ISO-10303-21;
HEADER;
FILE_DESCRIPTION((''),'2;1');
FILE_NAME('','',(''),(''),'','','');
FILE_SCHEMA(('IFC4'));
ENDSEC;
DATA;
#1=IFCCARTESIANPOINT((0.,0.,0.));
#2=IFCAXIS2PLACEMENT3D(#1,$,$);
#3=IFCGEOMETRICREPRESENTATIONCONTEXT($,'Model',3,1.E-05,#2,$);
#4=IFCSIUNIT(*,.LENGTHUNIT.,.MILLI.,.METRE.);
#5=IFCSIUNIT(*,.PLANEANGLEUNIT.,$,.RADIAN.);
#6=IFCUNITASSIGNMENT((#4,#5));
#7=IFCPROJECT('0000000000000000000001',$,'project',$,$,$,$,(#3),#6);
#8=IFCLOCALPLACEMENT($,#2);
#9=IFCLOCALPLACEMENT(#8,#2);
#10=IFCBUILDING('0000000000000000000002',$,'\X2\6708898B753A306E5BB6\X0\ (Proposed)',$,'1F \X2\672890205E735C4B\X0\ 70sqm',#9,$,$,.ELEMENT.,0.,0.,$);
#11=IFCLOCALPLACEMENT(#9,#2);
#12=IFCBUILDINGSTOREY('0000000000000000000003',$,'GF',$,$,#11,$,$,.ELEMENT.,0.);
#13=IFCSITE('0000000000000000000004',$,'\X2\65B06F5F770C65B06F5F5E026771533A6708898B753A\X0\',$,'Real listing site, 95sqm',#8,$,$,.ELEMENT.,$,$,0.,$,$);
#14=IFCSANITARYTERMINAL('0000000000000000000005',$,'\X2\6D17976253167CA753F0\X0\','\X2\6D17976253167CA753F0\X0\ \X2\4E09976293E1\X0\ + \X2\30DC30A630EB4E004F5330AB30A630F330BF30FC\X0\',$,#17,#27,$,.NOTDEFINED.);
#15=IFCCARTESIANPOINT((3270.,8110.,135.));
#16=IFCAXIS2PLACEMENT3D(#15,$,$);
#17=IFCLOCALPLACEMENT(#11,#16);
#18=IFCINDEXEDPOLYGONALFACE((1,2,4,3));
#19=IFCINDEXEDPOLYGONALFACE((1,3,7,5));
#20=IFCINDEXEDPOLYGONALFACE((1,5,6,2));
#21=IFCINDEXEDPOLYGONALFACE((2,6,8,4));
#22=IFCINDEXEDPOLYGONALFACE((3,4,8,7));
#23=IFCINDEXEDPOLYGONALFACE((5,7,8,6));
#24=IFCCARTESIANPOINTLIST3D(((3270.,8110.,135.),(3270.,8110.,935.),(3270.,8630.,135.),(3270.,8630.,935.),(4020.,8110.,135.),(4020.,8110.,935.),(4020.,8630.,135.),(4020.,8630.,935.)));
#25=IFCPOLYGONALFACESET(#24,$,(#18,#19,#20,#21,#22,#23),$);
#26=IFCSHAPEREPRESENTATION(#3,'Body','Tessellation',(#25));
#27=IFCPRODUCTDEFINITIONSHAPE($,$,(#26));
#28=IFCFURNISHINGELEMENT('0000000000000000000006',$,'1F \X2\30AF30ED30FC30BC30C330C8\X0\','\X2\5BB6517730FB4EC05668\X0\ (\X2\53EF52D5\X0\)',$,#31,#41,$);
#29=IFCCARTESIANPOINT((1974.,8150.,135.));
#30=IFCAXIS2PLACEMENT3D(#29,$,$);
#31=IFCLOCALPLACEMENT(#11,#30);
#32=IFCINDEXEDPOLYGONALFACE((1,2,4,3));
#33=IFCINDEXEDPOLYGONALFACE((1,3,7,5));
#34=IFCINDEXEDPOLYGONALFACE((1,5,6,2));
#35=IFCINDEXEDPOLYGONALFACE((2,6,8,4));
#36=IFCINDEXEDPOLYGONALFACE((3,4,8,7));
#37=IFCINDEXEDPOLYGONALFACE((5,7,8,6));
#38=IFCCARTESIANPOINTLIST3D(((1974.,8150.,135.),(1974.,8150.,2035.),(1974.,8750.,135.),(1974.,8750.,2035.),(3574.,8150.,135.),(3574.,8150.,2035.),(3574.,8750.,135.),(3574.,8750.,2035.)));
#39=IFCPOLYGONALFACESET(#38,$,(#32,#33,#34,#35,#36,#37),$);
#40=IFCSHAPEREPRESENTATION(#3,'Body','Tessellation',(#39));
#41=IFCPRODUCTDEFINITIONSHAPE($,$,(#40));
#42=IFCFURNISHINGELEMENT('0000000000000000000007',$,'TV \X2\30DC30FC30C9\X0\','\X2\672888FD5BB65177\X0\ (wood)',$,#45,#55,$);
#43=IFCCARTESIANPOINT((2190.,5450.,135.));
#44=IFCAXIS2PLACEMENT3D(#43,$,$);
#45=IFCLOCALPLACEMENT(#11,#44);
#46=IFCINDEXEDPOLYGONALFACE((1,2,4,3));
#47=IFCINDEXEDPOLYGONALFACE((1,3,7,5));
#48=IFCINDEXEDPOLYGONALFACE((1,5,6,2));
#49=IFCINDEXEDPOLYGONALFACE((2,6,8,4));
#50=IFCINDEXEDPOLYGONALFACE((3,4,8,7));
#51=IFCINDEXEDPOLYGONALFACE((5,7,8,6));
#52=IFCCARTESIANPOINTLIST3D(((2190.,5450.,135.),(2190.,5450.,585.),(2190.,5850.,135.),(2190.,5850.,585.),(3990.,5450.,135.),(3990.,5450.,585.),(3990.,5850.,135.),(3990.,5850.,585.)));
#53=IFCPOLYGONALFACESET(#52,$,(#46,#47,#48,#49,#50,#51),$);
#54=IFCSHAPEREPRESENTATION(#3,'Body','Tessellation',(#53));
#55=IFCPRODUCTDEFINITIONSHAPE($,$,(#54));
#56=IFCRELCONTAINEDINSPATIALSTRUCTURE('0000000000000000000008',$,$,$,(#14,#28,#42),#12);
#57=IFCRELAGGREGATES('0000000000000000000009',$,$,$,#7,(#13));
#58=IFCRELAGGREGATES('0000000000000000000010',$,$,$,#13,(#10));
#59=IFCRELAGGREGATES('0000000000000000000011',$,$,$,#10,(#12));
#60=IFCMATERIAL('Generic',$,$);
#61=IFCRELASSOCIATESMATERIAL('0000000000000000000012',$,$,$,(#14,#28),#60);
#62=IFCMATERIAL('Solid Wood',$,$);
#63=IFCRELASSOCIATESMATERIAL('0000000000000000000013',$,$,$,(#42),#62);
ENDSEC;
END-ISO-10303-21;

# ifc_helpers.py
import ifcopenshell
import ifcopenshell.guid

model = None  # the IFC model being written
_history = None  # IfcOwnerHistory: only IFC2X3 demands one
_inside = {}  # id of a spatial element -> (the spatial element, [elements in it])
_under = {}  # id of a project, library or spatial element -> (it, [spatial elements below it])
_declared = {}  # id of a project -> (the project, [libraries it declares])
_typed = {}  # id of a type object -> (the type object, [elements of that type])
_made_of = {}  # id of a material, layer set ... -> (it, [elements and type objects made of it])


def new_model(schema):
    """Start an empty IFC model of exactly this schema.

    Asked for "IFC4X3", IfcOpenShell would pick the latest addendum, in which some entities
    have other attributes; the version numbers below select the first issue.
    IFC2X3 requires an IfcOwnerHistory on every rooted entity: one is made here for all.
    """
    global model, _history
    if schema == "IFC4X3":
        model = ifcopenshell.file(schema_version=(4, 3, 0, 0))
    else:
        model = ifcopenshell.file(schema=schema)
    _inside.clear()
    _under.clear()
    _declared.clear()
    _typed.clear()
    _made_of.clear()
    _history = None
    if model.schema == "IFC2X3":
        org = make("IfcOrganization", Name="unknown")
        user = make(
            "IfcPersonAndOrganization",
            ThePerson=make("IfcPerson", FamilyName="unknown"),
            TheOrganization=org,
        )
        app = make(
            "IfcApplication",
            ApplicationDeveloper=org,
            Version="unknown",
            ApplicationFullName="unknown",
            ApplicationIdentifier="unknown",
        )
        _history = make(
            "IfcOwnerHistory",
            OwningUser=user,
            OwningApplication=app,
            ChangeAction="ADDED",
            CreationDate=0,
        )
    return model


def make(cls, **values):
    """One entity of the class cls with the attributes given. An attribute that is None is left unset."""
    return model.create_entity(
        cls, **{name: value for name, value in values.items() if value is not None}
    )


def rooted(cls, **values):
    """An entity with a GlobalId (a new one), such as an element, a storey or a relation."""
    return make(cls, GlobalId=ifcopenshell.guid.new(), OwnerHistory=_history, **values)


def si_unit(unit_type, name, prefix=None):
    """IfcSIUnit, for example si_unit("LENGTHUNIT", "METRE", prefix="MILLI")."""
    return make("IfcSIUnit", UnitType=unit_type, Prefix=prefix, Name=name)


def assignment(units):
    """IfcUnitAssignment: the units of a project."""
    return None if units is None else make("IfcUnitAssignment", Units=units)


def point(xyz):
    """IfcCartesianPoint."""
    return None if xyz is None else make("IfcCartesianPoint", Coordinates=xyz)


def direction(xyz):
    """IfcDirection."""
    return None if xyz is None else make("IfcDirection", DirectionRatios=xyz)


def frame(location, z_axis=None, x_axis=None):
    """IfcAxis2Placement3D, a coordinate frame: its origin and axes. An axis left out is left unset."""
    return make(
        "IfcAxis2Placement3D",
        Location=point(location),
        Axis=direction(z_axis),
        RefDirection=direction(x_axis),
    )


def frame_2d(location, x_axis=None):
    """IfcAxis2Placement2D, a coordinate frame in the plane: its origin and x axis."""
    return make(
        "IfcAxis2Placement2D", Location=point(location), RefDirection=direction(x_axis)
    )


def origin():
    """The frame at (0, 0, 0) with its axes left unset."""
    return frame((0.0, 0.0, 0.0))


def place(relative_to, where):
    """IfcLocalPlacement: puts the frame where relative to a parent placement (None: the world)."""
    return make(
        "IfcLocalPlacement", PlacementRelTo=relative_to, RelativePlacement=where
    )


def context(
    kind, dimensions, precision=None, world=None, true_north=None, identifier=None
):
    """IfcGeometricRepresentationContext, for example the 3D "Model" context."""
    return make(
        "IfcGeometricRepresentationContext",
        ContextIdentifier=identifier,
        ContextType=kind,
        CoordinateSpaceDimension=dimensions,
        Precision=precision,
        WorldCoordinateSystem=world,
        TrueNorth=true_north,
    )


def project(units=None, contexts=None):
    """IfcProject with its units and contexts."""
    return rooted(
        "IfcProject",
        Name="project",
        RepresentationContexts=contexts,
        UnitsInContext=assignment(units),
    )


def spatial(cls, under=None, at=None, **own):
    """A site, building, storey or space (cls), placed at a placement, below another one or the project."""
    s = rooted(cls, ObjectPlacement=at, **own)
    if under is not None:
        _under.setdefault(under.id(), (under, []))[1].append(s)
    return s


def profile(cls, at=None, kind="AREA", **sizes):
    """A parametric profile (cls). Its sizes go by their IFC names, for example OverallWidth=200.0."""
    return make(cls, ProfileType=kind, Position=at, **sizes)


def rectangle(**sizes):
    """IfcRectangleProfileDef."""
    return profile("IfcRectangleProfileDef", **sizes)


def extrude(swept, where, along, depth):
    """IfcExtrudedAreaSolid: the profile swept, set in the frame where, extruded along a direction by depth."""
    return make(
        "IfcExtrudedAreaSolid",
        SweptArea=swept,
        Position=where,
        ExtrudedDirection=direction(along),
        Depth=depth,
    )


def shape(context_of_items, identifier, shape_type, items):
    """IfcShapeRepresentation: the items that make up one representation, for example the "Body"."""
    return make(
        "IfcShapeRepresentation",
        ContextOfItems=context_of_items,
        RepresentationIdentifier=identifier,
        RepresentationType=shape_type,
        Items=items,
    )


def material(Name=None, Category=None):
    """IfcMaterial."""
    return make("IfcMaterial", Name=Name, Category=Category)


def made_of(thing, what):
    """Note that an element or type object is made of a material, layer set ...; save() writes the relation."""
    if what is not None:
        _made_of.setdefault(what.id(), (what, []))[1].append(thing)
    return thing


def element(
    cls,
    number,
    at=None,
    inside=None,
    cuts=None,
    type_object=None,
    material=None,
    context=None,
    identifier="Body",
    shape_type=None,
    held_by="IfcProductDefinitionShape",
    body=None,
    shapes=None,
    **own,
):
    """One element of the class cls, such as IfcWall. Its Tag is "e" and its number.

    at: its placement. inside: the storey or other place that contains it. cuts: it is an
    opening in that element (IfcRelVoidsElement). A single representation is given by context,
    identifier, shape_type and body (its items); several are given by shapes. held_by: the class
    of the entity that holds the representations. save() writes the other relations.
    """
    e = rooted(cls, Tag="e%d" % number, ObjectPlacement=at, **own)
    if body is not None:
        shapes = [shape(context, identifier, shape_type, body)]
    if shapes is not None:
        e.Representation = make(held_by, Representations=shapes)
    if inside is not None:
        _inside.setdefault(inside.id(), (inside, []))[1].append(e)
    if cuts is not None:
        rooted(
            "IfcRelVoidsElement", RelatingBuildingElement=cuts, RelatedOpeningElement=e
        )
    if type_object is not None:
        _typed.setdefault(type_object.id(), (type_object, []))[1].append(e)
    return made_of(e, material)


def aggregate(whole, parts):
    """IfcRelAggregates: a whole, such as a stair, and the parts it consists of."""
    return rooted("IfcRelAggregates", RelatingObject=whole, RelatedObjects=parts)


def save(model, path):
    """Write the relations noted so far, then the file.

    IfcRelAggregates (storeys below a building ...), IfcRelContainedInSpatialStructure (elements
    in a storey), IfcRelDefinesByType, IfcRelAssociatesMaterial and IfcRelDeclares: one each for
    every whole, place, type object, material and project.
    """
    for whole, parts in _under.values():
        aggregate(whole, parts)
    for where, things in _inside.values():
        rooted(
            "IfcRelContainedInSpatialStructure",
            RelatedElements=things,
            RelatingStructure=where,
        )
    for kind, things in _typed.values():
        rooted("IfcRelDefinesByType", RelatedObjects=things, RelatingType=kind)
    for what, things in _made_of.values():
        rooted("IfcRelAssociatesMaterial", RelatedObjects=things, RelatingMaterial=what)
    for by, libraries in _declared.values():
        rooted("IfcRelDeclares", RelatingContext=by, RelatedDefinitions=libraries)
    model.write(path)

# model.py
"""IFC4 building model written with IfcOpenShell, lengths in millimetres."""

from ifc_helpers import new_model, si_unit, frame, frame_2d, origin, place, context, project, spatial, rectangle, extrude, material, element, save


model = new_model("IFC4")

# Units and contexts
model_context = context("Model", 3, precision=1e-05, world=origin())
ifc_project = project(units=[si_unit("LENGTHUNIT", "METRE", prefix="MILLI"), si_unit("PLANEANGLEUNIT", "RADIAN")], contexts=[model_context])

# Site, building, storey
site_placement = place(None, origin())
site = spatial("IfcSite", under=ifc_project, at=site_placement, Name="新潟県新潟市東区月見町", ObjectType="Real listing site, 95sqm", CompositionType="ELEMENT", RefElevation=0.0)
building_placement = place(site_placement, origin())
building = spatial("IfcBuilding", under=site, at=building_placement, Name="月見町の家 (Proposed)", ObjectType="1F 木造平屋 70sqm", CompositionType="ELEMENT", ElevationOfRefHeight=0.0, ElevationOfTerrain=0.0)
storey_placement = place(building_placement, origin())
storey = spatial("IfcBuildingStorey", under=building, at=storey_placement, Name="GF", CompositionType="ELEMENT", Elevation=0.0)

# Shared definitions
ifc_material_1 = material(Name="Solid Wood")

# Shared definitions
ifc_material_2 = material(Name="Generic")

# Sanitary terminal
sanitary_terminal_1_placement = place(storey_placement, frame((3270.0, 8110.0, 135.0)))
element("IfcSanitaryTerminal", 1, at=sanitary_terminal_1_placement, inside=storey, material=ifc_material_2, Name="洗面化粧台", Description="洗面化粧台 三面鏡 + ボウル一体カウンター", PredefinedType="NOTDEFINED", context=model_context, shape_type="SweptSolid", body=[
    extrude(rectangle(XDim=750.0, YDim=520.0, at=frame_2d((375.0, 260.0))), frame((3270.0, 8110.0, 135.0)), (0.0, 0.0, 1.0), 800.0),
])

# Furnishing elements
furnishing_1_placement = place(storey_placement, frame((1974.0, 8150.0, 135.0)))
element("IfcFurnishingElement", 2, at=furnishing_1_placement, inside=storey, material=ifc_material_2, Name="1F クローゼット", Description="家具・什器 (可動)", context=model_context, shape_type="SweptSolid", body=[
    extrude(rectangle(XDim=1600.0, YDim=600.0, at=frame_2d((800.0, 300.0))), frame((1974.0, 8150.0, 135.0)), (0.0, 0.0, 1.0), 1900.0),
])
furnishing_2_placement = place(storey_placement, frame((2190.0, 5450.0, 135.0)))
element("IfcFurnishingElement", 3, at=furnishing_2_placement, inside=storey, material=ifc_material_1, Name="TV ボード", Description="木製家具 (wood)", context=model_context, shape_type="SweptSolid", body=[
    extrude(rectangle(XDim=1800.0, YDim=400.0, at=frame_2d((900.0, 200.0))), frame((2190.0, 5450.0, 135.0)), (0.0, 0.0, 1.0), 450.0),
])

save(model, "model.ifc")
